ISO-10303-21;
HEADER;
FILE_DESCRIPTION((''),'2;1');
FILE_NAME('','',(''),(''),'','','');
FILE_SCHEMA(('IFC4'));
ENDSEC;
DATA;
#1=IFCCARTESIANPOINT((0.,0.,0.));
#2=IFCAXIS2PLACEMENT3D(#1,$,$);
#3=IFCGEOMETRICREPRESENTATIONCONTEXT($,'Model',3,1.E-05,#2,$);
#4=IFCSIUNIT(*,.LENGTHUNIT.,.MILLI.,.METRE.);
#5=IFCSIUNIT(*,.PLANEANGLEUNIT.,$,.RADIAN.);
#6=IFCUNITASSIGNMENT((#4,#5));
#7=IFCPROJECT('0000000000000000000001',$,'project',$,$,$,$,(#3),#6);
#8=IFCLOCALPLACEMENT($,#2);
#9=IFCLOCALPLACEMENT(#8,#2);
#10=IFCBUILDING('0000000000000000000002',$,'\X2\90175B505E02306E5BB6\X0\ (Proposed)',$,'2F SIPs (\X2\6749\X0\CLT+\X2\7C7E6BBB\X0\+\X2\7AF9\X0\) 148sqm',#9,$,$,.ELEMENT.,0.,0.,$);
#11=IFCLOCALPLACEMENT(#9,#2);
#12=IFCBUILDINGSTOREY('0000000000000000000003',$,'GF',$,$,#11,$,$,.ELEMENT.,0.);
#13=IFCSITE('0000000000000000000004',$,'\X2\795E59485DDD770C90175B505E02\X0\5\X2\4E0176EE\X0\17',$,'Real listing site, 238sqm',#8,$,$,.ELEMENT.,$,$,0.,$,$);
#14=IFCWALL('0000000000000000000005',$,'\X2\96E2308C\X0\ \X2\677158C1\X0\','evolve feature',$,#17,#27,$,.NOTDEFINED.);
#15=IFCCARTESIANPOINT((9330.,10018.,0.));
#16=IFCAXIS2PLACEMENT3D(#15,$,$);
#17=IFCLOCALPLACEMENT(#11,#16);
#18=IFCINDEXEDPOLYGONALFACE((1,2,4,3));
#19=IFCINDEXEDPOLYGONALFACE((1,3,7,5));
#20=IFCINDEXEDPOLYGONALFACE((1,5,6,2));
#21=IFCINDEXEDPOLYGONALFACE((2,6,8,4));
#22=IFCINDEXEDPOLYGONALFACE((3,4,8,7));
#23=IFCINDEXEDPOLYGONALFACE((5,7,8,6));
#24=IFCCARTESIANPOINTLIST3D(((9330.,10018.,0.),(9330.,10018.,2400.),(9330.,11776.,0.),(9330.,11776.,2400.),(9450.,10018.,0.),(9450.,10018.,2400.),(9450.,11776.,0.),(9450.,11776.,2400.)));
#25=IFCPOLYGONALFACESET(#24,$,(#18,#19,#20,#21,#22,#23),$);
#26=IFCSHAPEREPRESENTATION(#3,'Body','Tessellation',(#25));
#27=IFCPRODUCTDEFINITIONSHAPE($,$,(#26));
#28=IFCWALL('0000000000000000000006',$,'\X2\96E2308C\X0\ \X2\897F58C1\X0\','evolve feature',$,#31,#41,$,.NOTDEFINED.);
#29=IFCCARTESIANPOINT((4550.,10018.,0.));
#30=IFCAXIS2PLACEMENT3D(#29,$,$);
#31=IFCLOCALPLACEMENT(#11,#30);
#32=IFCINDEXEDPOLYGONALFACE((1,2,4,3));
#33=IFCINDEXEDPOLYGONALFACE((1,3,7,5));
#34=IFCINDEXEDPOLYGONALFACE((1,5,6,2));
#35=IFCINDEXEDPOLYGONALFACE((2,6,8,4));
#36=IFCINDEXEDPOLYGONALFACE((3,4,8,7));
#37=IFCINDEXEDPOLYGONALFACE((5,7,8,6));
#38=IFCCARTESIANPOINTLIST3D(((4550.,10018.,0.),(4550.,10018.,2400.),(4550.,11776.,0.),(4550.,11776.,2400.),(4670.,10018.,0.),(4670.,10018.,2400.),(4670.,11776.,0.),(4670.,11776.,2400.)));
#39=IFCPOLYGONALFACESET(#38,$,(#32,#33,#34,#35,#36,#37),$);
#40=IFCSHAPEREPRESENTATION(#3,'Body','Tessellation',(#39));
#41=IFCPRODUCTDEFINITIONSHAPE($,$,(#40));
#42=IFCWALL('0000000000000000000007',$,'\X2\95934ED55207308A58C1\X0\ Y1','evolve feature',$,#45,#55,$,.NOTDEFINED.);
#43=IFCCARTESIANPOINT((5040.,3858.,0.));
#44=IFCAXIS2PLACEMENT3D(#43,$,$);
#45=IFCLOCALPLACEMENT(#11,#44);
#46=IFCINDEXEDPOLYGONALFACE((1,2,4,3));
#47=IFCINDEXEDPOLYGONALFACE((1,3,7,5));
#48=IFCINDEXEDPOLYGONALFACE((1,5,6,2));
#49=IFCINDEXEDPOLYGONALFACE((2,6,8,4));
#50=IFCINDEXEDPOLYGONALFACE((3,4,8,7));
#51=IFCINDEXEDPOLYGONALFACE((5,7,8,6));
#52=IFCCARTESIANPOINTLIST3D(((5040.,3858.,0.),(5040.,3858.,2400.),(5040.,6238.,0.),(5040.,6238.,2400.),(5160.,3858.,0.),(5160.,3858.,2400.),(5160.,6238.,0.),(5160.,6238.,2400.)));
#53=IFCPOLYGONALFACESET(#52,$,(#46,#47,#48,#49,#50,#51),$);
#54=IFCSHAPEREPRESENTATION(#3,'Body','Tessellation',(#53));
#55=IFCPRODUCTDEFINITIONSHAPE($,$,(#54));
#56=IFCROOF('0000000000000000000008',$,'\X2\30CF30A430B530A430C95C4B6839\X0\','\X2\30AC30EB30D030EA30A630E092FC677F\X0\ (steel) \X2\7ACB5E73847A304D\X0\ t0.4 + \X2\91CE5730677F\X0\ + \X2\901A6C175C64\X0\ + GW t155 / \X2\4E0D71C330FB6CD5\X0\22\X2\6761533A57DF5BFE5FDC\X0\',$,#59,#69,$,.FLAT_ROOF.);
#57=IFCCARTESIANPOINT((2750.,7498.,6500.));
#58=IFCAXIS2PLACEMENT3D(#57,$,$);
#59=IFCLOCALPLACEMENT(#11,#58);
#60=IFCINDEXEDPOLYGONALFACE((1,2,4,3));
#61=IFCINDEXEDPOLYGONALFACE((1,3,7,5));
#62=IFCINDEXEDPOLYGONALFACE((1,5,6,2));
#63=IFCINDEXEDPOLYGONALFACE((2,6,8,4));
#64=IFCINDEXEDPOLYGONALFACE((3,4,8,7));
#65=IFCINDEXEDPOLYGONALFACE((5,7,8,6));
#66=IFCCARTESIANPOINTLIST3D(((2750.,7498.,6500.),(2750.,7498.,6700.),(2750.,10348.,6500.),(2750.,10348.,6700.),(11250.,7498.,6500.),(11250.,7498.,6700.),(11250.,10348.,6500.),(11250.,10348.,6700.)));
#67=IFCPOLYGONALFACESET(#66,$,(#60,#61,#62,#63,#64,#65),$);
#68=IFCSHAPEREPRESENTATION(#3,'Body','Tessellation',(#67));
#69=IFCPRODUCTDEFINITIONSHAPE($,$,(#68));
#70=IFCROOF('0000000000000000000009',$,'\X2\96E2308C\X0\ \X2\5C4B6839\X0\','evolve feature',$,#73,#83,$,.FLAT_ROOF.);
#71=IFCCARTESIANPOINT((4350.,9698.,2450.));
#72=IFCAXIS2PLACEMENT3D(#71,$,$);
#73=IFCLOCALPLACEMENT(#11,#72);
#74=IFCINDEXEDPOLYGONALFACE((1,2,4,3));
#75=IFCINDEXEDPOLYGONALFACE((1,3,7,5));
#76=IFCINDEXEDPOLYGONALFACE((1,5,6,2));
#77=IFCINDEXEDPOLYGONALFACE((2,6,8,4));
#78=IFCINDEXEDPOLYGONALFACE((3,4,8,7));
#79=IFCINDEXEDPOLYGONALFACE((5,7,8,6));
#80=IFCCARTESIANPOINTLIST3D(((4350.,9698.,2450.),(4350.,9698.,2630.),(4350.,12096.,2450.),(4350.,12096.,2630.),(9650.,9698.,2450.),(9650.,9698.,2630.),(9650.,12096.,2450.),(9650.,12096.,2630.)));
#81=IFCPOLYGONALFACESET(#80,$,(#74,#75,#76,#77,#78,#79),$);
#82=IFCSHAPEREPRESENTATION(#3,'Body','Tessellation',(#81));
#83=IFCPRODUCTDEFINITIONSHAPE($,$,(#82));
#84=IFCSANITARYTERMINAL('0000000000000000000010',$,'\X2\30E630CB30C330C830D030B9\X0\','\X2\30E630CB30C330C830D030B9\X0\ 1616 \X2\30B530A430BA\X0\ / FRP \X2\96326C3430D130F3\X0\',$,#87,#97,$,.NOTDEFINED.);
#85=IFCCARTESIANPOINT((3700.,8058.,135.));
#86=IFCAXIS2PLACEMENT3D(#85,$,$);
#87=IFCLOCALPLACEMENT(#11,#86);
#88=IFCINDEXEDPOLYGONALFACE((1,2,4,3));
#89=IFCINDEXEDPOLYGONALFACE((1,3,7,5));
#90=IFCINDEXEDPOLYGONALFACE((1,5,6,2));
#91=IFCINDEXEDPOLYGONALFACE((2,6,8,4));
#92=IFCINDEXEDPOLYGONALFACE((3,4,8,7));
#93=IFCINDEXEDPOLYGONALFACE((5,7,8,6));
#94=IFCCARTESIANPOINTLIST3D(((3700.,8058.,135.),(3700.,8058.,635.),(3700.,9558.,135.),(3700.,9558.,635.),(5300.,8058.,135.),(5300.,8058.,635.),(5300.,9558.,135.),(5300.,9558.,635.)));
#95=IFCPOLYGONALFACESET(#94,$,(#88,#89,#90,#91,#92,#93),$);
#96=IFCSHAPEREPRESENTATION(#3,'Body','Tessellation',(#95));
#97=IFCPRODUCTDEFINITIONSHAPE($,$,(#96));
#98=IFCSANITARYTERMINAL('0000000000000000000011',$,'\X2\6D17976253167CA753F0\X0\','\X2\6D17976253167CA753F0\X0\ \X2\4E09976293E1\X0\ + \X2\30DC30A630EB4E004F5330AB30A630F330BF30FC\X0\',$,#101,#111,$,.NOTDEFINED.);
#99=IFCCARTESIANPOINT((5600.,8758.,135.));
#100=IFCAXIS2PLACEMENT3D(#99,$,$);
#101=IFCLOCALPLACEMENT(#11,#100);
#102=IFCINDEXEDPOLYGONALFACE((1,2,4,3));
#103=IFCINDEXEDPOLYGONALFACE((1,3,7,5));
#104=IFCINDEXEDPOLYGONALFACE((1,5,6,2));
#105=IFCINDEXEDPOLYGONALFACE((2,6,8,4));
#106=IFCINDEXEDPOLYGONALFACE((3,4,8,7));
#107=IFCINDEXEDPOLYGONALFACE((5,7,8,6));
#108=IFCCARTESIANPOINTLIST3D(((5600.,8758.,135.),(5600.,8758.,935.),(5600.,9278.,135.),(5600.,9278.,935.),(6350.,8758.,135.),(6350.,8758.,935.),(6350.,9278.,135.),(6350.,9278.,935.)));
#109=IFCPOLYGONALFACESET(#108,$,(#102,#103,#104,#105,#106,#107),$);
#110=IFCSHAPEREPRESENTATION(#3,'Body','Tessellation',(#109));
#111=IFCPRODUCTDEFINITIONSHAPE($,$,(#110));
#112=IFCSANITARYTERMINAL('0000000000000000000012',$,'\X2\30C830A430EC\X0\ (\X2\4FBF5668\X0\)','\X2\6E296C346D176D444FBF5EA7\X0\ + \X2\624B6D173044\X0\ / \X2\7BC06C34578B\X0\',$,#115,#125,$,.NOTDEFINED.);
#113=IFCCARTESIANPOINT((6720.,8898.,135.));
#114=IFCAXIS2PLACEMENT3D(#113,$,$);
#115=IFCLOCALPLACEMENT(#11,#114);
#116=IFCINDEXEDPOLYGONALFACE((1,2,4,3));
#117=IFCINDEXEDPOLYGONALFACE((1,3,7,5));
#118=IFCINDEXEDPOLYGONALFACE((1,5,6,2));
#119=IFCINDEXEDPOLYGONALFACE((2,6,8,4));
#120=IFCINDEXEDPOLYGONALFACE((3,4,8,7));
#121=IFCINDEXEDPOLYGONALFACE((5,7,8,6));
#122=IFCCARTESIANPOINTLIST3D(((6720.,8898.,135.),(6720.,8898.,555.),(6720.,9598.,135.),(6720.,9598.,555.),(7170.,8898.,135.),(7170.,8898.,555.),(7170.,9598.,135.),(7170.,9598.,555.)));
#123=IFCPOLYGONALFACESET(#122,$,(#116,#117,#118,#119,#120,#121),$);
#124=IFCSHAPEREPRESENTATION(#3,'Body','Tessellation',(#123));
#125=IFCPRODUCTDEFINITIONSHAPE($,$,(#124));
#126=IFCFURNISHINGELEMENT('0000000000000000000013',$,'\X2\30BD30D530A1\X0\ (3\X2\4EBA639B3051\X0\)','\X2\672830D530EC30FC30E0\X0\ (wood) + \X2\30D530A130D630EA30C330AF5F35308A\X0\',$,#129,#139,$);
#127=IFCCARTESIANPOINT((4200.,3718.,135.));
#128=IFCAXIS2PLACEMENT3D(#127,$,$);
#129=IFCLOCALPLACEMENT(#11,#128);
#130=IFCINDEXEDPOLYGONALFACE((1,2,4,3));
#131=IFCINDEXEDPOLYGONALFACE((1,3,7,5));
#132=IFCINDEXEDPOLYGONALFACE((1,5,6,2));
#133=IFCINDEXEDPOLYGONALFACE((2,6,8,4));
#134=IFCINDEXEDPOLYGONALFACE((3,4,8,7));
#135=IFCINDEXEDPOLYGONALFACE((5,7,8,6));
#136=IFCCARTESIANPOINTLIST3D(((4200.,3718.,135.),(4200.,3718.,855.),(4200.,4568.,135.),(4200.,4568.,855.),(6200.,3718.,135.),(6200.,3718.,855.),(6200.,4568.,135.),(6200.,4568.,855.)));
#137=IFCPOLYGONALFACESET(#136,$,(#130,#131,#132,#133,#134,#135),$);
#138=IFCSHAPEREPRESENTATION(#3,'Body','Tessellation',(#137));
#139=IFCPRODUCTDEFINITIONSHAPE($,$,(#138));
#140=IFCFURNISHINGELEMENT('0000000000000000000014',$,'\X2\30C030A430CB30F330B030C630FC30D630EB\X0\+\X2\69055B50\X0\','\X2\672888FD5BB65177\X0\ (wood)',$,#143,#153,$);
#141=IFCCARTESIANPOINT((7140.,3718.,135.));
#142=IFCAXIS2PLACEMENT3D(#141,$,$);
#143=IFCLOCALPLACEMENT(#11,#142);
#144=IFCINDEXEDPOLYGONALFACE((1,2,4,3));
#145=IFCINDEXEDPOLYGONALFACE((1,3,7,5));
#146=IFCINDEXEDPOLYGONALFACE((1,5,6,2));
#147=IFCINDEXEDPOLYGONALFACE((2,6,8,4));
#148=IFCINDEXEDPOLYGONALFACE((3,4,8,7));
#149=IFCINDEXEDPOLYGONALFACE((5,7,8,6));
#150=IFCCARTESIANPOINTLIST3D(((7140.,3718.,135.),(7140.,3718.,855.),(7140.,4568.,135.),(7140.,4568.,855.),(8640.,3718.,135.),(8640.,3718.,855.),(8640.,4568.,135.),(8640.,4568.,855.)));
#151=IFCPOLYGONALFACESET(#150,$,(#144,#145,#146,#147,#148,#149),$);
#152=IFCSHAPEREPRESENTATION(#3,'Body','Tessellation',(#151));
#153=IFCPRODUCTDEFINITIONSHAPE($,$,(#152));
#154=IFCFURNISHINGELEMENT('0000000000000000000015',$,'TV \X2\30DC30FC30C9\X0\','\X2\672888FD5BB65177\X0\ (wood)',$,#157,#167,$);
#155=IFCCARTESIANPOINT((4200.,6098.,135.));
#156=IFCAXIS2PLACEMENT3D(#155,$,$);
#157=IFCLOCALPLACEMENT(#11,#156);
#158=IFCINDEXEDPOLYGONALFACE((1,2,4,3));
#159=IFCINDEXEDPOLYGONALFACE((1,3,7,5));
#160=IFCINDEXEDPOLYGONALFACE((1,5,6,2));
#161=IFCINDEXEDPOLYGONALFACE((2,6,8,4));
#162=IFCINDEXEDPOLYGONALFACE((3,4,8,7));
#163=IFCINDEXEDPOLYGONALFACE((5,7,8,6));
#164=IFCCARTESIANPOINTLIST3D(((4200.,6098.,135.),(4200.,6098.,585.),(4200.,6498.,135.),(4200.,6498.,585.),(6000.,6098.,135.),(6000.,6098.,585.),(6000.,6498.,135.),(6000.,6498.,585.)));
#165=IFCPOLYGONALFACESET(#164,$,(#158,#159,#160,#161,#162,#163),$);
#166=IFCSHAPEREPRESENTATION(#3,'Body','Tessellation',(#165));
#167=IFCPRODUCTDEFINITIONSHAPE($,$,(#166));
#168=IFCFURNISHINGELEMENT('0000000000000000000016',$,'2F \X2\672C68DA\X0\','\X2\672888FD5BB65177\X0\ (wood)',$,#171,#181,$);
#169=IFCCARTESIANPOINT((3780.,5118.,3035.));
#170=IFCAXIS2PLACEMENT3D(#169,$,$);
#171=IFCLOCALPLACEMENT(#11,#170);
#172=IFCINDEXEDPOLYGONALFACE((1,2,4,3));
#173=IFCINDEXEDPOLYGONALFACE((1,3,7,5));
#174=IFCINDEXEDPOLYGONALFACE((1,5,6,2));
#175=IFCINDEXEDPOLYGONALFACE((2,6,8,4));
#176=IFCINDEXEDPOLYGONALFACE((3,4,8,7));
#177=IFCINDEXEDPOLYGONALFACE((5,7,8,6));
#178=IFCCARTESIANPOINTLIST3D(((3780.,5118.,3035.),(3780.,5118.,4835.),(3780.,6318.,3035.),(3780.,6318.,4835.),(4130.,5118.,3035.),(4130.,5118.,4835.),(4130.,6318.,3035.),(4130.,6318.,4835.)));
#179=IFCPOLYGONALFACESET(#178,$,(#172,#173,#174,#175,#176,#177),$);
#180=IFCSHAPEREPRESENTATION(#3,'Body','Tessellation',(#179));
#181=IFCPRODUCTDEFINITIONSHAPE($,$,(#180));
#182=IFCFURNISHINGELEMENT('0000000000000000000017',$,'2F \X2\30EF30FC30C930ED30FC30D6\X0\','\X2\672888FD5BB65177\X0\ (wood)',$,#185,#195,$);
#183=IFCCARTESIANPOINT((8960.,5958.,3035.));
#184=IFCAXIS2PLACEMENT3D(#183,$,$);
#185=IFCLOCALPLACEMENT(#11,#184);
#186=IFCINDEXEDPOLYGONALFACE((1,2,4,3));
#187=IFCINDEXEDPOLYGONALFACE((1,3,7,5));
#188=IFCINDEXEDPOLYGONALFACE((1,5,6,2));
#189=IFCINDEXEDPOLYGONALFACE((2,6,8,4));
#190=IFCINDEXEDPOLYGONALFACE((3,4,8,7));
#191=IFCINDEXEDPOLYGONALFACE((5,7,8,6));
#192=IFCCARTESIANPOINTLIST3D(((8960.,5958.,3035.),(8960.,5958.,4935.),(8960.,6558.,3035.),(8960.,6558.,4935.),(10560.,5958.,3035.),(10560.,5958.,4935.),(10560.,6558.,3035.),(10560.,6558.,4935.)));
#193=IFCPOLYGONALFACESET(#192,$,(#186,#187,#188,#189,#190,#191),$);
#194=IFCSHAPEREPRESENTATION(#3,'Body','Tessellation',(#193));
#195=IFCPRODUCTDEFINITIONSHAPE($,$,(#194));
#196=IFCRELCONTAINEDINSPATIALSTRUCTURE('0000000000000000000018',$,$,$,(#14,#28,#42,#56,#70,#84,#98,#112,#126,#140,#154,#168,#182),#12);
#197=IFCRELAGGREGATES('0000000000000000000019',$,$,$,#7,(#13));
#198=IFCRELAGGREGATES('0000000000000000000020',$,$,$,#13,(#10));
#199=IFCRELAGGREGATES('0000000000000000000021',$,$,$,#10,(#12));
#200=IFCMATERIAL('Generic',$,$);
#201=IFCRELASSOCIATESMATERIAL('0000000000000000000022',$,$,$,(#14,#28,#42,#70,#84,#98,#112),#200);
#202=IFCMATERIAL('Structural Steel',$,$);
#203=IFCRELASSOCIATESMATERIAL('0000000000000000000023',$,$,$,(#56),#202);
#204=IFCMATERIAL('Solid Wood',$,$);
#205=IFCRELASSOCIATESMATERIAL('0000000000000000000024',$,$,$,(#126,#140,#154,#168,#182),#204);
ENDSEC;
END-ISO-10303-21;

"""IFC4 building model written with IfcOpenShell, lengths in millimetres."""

from ifc_helpers import new_model, si_unit, frame, frame_2d, origin, place, context, project, spatial, rectangle, extrude, material, element, save


model = new_model("IFC4")

# Units and contexts
model_context = context("Model", 3, precision=1e-05, world=origin())
ifc_project = project(units=[si_unit("LENGTHUNIT", "METRE", prefix="MILLI"), si_unit("PLANEANGLEUNIT", "RADIAN")], contexts=[model_context])

# Site, building, storey
site_placement = place(None, origin())
site = spatial("IfcSite", under=ifc_project, at=site_placement, Name="神奈川県逗子市5丁目17", ObjectType="Real listing site, 238sqm", CompositionType="ELEMENT", RefElevation=0.0)
building_placement = place(site_placement, origin())
building = spatial("IfcBuilding", under=site, at=building_placement, Name="逗子市の家 (Proposed)", ObjectType="2F SIPs (杉CLT+籾殻+竹) 148sqm", CompositionType="ELEMENT", ElevationOfRefHeight=0.0, ElevationOfTerrain=0.0)
storey_placement = place(building_placement, origin())
storey = spatial("IfcBuildingStorey", under=building, at=storey_placement, Name="GF", CompositionType="ELEMENT", Elevation=0.0)

# Shared definitions
ifc_material_1 = material(Name="Generic")

# Shared definitions
ifc_material_2 = material(Name="Solid Wood")

# Walls
wall_1_placement = place(storey_placement, frame((9330.0, 10018.0, 0.0)))
element("IfcWall", 1, at=wall_1_placement, inside=storey, material=ifc_material_1, Name="離れ 東壁", Description="evolve feature", PredefinedType="NOTDEFINED", context=model_context, shape_type="SweptSolid", body=[
    extrude(rectangle(XDim=120.0, YDim=1758.0, at=frame_2d((60.0, 879.0))), frame((9330.0, 10018.0, 0.0)), (0.0, 0.0, 1.0), 2400.0),
])
wall_2_placement = place(storey_placement, frame((4550.0, 10018.0, 0.0)))
element("IfcWall", 2, at=wall_2_placement, inside=storey, material=ifc_material_1, Name="離れ 西壁", Description="evolve feature", PredefinedType="NOTDEFINED", context=model_context, shape_type="SweptSolid", body=[
    extrude(rectangle(XDim=120.0, YDim=1758.0, at=frame_2d((60.0, 879.0))), frame((4550.0, 10018.0, 0.0)), (0.0, 0.0, 1.0), 2400.0),
])
wall_3_placement = place(storey_placement, frame((5040.0, 3858.0, 0.0)))
element("IfcWall", 3, at=wall_3_placement, inside=storey, material=ifc_material_1, Name="間仕切り壁 Y1", Description="evolve feature", PredefinedType="NOTDEFINED", context=model_context, shape_type="SweptSolid", body=[
    extrude(rectangle(XDim=120.0, YDim=2380.0, at=frame_2d((60.0, 1190.0))), frame((5040.0, 3858.0, 0.0)), (0.0, 0.0, 1.0), 2400.0),
])

# Roofs
ifc_material_3 = material(Name="Structural Steel")
roof_1_placement = place(storey_placement, frame((2750.0, 7498.0, 6500.0)))
element("IfcRoof", 4, at=roof_1_placement, inside=storey, material=ifc_material_3, Name="ハイサイド屋根", Description="ガルバリウム鋼板 (steel) 立平葺き t0.4 + 野地板 + 通気層 + GW t155 / 不燃・法22条区域対応", PredefinedType="FLAT_ROOF", context=model_context, shape_type="SweptSolid", body=[
    extrude(rectangle(XDim=8500.0, YDim=2850.0, at=frame_2d((4250.0, 1425.0))), frame((2750.0, 7498.0, 6500.0)), (0.0, 0.0, 1.0), 200.0),
])
roof_2_placement = place(storey_placement, frame((4350.0, 9698.0, 2450.0)))
element("IfcRoof", 5, at=roof_2_placement, inside=storey, material=ifc_material_1, Name="離れ 屋根", Description="evolve feature", PredefinedType="FLAT_ROOF", context=model_context, shape_type="SweptSolid", body=[
    extrude(rectangle(XDim=5300.0, YDim=2398.0, at=frame_2d((2650.0, 1199.0))), frame((4350.0, 9698.0, 2450.0)), (0.0, 0.0, 1.0), 180.0),
])

# Sanitary terminals
sanitary_terminal_1_placement = place(storey_placement, frame((3700.0, 8058.0, 135.0)))
element("IfcSanitaryTerminal", 6, at=sanitary_terminal_1_placement, inside=storey, material=ifc_material_1, Name="ユニットバス", Description="ユニットバス 1616 サイズ / FRP 防水パン", PredefinedType="NOTDEFINED", context=model_context, shape_type="SweptSolid", body=[
    extrude(rectangle(XDim=1600.0, YDim=1500.0, at=frame_2d((800.0, 750.0))), frame((3700.0, 8058.0, 135.0)), (0.0, 0.0, 1.0), 500.0),
])
sanitary_terminal_2_placement = place(storey_placement, frame((5600.0, 8758.0, 135.0)))
element("IfcSanitaryTerminal", 7, at=sanitary_terminal_2_placement, inside=storey, material=ifc_material_1, Name="洗面化粧台", Description="洗面化粧台 三面鏡 + ボウル一体カウンター", PredefinedType="NOTDEFINED", context=model_context, shape_type="SweptSolid", body=[
    extrude(rectangle(XDim=750.0, YDim=520.0, at=frame_2d((375.0, 260.0))), frame((5600.0, 8758.0, 135.0)), (0.0, 0.0, 1.0), 800.0),
])
sanitary_terminal_3_placement = place(storey_placement, frame((6720.0, 8898.0, 135.0)))
element("IfcSanitaryTerminal", 8, at=sanitary_terminal_3_placement, inside=storey, material=ifc_material_1, Name="トイレ (便器)", Description="温水洗浄便座 + 手洗い / 節水型", PredefinedType="NOTDEFINED", context=model_context, shape_type="SweptSolid", body=[
    extrude(rectangle(XDim=450.0, YDim=700.0, at=frame_2d((225.0, 350.0))), frame((6720.0, 8898.0, 135.0)), (0.0, 0.0, 1.0), 420.0),
])

# Furnishing elements
furnishing_1_placement = place(storey_placement, frame((4200.0, 3718.0, 135.0)))
element("IfcFurnishingElement", 9, at=furnishing_1_placement, inside=storey, material=ifc_material_2, Name="ソファ (3人掛け)", Description="木フレーム (wood) + ファブリック張り", context=model_context, shape_type="SweptSolid", body=[
    extrude(rectangle(XDim=2000.0, YDim=850.0, at=frame_2d((1000.0, 425.0))), frame((4200.0, 3718.0, 135.0)), (0.0, 0.0, 1.0), 720.0),
])
furnishing_2_placement = place(storey_placement, frame((7140.0, 3718.0, 135.0)))
element("IfcFurnishingElement", 10, at=furnishing_2_placement, inside=storey, material=ifc_material_2, Name="ダイニングテーブル+椅子", Description="木製家具 (wood)", context=model_context, shape_type="SweptSolid", body=[
    extrude(rectangle(XDim=1500.0, YDim=850.0, at=frame_2d((750.0, 425.0))), frame((7140.0, 3718.0, 135.0)), (0.0, 0.0, 1.0), 720.0),
])
furnishing_3_placement = place(storey_placement, frame((4200.0, 6098.0, 135.0)))
element("IfcFurnishingElement", 11, at=furnishing_3_placement, inside=storey, material=ifc_material_2, Name="TV ボード", Description="木製家具 (wood)", context=model_context, shape_type="SweptSolid", body=[
    extrude(rectangle(XDim=1800.0, YDim=400.0, at=frame_2d((900.0, 200.0))), frame((4200.0, 6098.0, 135.0)), (0.0, 0.0, 1.0), 450.0),
])
furnishing_4_placement = place(storey_placement, frame((3780.0, 5118.0, 3035.0)))
element("IfcFurnishingElement", 12, at=furnishing_4_placement, inside=storey, material=ifc_material_2, Name="2F 本棚", Description="木製家具 (wood)", context=model_context, shape_type="SweptSolid", body=[
    extrude(rectangle(XDim=350.0, YDim=1200.0, at=frame_2d((175.0, 600.0))), frame((3780.0, 5118.0, 3035.0)), (0.0, 0.0, 1.0), 1800.0),
])
furnishing_5_placement = place(storey_placement, frame((8960.0, 5958.0, 3035.0)))
element("IfcFurnishingElement", 13, at=furnishing_5_placement, inside=storey, material=ifc_material_2, Name="2F ワードローブ", Description="木製家具 (wood)", context=model_context, shape_type="SweptSolid", body=[
    extrude(rectangle(XDim=1600.0, YDim=600.0, at=frame_2d((800.0, 300.0))), frame((8960.0, 5958.0, 3035.0)), (0.0, 0.0, 1.0), 1900.0),
])

save(model, "model.ifc")
